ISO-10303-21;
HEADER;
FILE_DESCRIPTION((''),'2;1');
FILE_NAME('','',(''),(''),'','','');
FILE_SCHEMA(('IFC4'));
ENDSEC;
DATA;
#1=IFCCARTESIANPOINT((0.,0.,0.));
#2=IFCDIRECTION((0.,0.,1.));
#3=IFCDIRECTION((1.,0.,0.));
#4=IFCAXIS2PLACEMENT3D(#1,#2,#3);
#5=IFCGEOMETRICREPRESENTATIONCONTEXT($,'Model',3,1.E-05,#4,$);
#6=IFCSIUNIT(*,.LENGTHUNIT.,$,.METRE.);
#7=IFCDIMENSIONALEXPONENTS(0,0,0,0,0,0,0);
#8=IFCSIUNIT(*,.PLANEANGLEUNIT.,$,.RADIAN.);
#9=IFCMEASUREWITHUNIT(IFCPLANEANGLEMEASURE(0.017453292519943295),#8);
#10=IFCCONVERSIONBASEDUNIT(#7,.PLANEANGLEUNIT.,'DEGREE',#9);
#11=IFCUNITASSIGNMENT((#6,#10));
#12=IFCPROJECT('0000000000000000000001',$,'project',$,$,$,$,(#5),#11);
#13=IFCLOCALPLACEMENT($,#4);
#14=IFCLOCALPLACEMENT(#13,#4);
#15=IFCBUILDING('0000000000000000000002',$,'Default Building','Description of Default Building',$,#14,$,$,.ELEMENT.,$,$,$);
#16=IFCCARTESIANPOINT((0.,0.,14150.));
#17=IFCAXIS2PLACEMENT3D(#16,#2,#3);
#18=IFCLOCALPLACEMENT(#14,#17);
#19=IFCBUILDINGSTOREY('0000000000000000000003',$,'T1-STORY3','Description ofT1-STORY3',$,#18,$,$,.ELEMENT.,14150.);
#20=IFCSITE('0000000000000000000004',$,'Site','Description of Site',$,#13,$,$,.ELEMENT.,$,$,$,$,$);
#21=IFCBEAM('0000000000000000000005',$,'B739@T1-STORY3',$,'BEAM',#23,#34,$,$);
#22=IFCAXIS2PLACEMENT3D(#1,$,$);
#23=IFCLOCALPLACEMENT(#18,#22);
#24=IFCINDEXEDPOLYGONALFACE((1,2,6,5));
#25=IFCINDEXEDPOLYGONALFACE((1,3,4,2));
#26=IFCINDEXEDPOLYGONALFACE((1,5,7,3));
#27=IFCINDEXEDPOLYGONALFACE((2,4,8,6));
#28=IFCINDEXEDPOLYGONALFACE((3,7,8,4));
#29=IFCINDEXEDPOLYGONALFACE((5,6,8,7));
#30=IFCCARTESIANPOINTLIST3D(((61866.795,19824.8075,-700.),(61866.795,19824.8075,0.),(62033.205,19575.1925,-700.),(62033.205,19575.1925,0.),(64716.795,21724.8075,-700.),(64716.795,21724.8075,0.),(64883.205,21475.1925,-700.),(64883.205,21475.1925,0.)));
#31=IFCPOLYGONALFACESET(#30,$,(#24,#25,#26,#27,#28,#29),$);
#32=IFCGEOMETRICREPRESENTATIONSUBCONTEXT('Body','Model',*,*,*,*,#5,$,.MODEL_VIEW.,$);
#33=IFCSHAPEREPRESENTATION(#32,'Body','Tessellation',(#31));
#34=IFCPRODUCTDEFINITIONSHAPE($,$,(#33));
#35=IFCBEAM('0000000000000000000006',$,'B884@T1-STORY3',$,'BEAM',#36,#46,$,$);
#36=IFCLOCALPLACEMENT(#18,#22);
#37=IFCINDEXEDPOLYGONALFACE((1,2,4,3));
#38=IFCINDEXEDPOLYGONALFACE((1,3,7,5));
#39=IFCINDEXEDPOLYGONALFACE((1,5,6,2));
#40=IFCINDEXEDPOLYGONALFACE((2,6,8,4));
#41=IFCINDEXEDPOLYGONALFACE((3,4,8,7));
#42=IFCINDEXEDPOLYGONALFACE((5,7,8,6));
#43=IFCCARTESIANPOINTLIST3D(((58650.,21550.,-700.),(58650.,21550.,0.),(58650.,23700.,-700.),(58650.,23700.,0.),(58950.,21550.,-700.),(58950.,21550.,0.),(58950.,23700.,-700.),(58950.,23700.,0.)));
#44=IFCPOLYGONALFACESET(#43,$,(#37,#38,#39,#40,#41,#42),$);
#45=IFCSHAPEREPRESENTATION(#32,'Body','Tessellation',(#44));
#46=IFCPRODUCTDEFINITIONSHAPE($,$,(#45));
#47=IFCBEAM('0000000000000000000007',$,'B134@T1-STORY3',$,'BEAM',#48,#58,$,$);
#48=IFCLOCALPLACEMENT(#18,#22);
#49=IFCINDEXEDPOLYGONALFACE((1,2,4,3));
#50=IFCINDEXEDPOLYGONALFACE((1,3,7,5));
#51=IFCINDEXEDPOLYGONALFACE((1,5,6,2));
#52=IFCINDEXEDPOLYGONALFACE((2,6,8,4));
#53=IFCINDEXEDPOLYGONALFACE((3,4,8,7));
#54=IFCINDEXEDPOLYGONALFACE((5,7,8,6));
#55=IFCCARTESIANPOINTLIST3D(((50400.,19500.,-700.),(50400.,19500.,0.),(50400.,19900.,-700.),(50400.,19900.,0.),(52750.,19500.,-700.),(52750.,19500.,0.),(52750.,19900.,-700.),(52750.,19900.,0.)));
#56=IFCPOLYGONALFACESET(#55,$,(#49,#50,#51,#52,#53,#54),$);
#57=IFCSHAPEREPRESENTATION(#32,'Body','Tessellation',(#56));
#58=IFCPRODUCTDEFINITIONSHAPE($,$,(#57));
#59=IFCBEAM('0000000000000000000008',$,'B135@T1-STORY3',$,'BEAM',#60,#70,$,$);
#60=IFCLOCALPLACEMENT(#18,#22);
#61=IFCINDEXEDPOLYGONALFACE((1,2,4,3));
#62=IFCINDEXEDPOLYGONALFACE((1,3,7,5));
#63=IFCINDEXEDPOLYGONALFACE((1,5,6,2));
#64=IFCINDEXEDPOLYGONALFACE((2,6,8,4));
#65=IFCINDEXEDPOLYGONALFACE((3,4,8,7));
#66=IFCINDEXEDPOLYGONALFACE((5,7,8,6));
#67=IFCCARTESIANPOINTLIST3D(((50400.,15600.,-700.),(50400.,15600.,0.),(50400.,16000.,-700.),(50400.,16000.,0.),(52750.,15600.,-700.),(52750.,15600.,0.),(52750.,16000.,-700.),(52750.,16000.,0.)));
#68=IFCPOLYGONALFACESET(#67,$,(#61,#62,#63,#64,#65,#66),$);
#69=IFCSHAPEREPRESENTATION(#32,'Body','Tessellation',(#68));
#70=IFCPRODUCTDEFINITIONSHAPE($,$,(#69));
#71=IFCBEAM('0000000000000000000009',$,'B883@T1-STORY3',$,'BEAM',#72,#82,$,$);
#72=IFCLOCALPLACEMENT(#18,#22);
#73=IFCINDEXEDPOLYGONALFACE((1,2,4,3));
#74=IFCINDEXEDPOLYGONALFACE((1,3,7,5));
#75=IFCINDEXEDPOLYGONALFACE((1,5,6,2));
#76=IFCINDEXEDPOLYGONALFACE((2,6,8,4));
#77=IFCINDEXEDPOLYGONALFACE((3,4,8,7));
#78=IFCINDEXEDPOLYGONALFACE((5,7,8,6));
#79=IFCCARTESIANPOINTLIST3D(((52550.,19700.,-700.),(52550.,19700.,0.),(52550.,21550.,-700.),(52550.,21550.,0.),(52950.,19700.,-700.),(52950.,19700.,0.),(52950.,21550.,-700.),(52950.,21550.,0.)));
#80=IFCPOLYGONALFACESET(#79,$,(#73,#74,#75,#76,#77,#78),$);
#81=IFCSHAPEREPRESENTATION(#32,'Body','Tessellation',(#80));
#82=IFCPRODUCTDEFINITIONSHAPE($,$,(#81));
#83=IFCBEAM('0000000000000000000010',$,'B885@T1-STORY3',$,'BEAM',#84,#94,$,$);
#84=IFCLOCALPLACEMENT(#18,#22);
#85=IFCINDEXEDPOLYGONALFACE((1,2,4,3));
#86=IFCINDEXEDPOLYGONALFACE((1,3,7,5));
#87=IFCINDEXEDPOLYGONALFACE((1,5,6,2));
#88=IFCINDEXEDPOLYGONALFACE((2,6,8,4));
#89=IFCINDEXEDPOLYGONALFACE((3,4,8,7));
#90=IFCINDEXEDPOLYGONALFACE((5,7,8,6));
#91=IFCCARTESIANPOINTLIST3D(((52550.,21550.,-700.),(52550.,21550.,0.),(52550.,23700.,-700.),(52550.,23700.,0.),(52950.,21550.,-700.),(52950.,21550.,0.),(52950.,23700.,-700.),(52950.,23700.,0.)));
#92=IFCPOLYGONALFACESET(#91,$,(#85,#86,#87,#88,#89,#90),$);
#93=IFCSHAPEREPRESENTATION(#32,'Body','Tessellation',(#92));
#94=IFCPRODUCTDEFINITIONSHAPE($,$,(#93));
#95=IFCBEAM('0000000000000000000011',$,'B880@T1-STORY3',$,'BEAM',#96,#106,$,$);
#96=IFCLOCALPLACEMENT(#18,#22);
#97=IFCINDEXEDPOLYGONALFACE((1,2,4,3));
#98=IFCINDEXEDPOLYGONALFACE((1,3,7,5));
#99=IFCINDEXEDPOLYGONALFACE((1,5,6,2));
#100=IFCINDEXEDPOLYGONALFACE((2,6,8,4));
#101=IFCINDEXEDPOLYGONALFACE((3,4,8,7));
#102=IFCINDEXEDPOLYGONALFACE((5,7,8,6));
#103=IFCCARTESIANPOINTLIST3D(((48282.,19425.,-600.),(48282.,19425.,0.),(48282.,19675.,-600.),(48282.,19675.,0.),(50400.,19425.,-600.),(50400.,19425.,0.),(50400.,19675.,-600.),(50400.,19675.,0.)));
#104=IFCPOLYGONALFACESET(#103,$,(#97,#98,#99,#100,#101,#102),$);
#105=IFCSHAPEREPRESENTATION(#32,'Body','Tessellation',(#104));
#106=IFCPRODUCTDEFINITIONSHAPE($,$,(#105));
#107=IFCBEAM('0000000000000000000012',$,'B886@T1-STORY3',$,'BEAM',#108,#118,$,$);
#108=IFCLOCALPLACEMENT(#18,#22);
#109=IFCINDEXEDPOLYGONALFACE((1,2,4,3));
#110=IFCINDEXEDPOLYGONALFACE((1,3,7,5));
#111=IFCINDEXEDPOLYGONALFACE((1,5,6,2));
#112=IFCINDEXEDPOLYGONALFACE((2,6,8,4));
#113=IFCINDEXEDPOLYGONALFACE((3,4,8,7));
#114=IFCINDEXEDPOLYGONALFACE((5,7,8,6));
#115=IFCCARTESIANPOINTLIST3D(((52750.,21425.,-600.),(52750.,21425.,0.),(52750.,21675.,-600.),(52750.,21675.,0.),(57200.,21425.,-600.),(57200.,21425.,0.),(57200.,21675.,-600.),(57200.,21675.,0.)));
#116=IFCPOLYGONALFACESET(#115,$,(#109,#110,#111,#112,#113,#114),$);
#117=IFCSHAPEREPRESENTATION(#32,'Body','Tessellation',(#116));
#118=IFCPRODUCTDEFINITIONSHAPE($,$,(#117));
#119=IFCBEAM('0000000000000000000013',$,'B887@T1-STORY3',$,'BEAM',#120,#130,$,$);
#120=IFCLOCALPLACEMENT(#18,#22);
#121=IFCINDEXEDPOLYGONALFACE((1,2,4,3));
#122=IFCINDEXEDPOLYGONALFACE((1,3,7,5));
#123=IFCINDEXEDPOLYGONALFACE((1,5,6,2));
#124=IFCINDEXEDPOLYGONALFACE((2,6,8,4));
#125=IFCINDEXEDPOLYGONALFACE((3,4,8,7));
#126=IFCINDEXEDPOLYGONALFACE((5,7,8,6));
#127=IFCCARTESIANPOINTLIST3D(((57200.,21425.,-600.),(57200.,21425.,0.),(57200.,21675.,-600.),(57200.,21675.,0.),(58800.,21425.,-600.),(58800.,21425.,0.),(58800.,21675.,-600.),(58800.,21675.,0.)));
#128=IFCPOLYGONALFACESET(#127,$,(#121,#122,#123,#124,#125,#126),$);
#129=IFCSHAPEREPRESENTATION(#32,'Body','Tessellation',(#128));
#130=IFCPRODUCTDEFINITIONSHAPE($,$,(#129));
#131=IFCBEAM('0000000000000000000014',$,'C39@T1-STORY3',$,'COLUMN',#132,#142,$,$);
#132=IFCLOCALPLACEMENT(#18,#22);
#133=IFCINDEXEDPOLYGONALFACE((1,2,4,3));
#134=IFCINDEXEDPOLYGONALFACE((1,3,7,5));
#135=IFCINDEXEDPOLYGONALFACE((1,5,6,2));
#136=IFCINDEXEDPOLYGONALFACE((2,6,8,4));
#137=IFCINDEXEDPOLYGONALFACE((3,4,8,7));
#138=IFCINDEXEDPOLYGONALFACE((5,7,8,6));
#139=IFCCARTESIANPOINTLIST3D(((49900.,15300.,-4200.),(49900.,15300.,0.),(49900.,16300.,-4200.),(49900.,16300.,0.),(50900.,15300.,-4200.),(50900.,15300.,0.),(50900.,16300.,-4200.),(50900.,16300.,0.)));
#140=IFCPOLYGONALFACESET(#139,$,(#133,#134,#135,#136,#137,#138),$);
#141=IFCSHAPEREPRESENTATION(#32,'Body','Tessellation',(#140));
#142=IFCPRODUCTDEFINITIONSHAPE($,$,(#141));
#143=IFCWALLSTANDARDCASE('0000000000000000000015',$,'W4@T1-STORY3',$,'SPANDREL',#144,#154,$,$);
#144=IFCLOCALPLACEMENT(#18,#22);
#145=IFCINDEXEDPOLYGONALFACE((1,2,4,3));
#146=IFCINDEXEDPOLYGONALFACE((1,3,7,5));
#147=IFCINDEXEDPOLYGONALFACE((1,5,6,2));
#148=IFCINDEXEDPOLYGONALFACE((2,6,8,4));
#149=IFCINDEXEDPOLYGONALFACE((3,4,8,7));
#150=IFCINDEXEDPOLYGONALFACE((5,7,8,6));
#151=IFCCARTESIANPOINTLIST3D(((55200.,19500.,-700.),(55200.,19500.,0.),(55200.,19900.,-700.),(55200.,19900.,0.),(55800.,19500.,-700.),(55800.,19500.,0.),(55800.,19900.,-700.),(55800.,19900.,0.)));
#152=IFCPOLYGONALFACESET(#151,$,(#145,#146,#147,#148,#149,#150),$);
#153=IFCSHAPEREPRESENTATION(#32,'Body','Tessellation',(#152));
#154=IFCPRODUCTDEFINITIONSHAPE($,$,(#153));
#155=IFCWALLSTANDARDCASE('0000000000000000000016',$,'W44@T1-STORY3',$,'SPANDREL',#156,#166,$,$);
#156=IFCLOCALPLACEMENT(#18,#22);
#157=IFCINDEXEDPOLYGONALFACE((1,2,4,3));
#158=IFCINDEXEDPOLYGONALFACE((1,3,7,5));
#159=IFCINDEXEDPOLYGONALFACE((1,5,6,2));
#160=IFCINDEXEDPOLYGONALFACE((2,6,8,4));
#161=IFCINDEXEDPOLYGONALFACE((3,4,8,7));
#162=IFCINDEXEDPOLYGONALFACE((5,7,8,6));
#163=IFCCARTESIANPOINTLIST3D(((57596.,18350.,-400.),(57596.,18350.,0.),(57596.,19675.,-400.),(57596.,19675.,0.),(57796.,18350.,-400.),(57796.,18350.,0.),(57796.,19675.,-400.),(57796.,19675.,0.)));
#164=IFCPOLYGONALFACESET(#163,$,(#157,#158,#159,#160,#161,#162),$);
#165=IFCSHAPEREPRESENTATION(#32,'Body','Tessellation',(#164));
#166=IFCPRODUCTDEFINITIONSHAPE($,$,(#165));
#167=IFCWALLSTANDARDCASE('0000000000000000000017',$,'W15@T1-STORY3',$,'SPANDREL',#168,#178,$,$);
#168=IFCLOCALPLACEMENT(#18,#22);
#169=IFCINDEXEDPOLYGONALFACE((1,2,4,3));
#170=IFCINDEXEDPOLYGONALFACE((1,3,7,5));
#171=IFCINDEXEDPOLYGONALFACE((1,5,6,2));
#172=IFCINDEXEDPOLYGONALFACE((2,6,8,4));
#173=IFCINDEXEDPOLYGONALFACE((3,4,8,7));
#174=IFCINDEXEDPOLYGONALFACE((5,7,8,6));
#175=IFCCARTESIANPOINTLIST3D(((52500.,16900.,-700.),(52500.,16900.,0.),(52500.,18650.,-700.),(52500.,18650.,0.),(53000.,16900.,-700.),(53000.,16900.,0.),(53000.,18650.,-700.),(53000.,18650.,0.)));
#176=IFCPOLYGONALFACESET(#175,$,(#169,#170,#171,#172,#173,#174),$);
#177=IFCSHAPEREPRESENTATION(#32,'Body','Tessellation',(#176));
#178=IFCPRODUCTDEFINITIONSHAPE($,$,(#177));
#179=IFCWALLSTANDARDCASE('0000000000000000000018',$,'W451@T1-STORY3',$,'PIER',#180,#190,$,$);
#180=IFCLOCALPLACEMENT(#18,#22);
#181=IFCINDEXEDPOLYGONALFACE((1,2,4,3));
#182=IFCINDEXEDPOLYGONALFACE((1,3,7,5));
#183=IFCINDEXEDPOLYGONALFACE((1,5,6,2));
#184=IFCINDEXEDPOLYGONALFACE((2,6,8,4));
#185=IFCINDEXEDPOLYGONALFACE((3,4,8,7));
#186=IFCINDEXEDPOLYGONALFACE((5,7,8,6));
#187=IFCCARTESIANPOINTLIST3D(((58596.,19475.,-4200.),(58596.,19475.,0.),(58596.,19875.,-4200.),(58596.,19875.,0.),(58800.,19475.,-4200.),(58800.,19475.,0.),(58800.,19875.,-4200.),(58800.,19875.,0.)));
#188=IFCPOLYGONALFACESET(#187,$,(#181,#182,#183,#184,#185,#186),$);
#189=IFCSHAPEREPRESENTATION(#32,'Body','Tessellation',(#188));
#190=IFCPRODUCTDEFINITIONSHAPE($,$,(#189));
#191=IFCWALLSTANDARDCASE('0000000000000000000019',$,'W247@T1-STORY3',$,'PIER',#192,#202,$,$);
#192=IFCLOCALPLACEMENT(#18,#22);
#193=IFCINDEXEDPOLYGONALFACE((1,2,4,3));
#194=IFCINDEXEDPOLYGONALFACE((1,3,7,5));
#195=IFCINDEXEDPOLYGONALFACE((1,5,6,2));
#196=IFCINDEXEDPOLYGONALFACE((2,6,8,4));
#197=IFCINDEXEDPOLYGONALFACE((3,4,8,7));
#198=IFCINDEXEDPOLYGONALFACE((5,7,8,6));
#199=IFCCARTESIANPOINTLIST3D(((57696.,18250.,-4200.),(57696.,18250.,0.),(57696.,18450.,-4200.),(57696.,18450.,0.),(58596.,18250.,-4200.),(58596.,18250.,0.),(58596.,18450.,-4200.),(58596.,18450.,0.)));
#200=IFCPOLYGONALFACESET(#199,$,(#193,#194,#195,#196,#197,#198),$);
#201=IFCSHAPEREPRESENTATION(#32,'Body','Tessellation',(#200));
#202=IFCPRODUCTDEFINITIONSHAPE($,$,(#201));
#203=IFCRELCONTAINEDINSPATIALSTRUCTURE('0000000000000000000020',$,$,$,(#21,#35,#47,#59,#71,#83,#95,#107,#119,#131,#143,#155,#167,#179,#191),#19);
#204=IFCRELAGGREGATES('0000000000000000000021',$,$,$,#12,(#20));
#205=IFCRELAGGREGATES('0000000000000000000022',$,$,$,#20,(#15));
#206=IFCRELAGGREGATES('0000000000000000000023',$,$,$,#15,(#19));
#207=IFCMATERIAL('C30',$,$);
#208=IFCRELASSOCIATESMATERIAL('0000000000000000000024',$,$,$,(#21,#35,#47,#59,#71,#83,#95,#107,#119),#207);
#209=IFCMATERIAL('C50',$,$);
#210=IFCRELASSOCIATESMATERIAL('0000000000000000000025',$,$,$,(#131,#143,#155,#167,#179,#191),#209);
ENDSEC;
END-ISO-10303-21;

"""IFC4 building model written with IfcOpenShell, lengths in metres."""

from ifc_helpers import new_model, entity, si_unit, converted_unit, frame, origin_with_axes, place, context, subcontext, project, spatial, indexed_curve, rectangle, outline, extrude, material, element, save


model = new_model("IFC4")

# Units and contexts
model_context = context("Model", 3, precision=1e-05, world=origin_with_axes())
body_context = subcontext(model_context, "Body", "Model", "MODEL_VIEW")
ifc_project = project(units=[si_unit("LENGTHUNIT", "METRE"), converted_unit("PLANEANGLEUNIT", "DEGREE", entity("IfcPlaneAngleMeasure", 0.017453292519943295), si_unit("PLANEANGLEUNIT", "RADIAN"), dimensions=[0, 0, 0, 0, 0, 0, 0])], contexts=[model_context])

# Site, building, storey
site_placement = place(None, origin_with_axes())
site = spatial("IfcSite", under=ifc_project, at=site_placement, Name="Site", Description="Description of Site", CompositionType="ELEMENT")
building_placement = place(site_placement, origin_with_axes())
building = spatial("IfcBuilding", under=site, at=building_placement, Name="Default Building", Description="Description of Default Building", CompositionType="ELEMENT")
storey_placement = place(building_placement, frame((0.0, 0.0, 14150.0), z_axis=(0.0, 0.0, 1.0), x_axis=(1.0, 0.0, 0.0)))
storey = spatial("IfcBuildingStorey", under=building, at=storey_placement, Name="T1-STORY3", Description="Description ofT1-STORY3", CompositionType="ELEMENT", Elevation=14150.0)

# Beams
ifc_material_1 = material(Name="C30")
beam_1_placement = place(storey_placement, frame((61950.0, 19700.0, -350.0), z_axis=(0.83205, 0.5547, 0.0), x_axis=(-0.5547, 0.83205, 0.0)))
element("IfcBeam", 1, at=beam_1_placement, inside=storey, material=ifc_material_1, Name="B739@T1-STORY3", ObjectType="BEAM", context=body_context, shape_type="SweptSolid", body=[
    extrude(rectangle(XDim=300.0, YDim=700.0), origin_with_axes(), (0.0, 0.0, 1.0), 3425.2737),
])
beam_2_placement = place(storey_placement, frame((58800.0, 21550.0, -350.0), z_axis=(0.0, 1.0, 0.0), x_axis=(-1.0, 0.0, 0.0)))
element("IfcBeam", 2, at=beam_2_placement, inside=storey, material=ifc_material_1, Name="B884@T1-STORY3", ObjectType="BEAM", context=body_context, shape_type="SweptSolid", body=[
    extrude(rectangle(XDim=300.0, YDim=700.0), origin_with_axes(), (0.0, 0.0, 1.0), 2150.0),
])
for number, where, z_axis, x_axis, name in (
    (3, (50400.0, 19700.0, -350.0), (1.0, 0.0, 0.0), (0.0, 1.0, 0.0), "B134@T1-STORY3"),
    (4, (50400.0, 15800.0, -350.0), (1.0, 0.0, 0.0), (0.0, 1.0, 0.0), "B135@T1-STORY3"),
):
    element("IfcBeam", number, at=place(storey_placement, frame(where, z_axis=z_axis, x_axis=x_axis)), inside=storey, material=ifc_material_1, Name=name, ObjectType="BEAM", context=body_context, shape_type="SweptSolid", body=[
        extrude(rectangle(XDim=400.0, YDim=700.0), origin_with_axes(), (0.0, 0.0, 1.0), 2350.0),
    ])
beam_3_placement = place(storey_placement, frame((52750.0, 19700.0, -350.0), z_axis=(0.0, 1.0, 0.0), x_axis=(-1.0, 0.0, 0.0)))
element("IfcBeam", 5, at=beam_3_placement, inside=storey, material=ifc_material_1, Name="B883@T1-STORY3", ObjectType="BEAM", context=body_context, shape_type="SweptSolid", body=[
    extrude(rectangle(XDim=400.0, YDim=700.0), origin_with_axes(), (0.0, 0.0, 1.0), 1850.0),
])
beam_4_placement = place(storey_placement, frame((52750.0, 21550.0, -350.0), z_axis=(0.0, 1.0, 0.0), x_axis=(-1.0, 0.0, 0.0)))
element("IfcBeam", 6, at=beam_4_placement, inside=storey, material=ifc_material_1, Name="B885@T1-STORY3", ObjectType="BEAM", context=body_context, shape_type="SweptSolid", body=[
    extrude(rectangle(XDim=400.0, YDim=700.0), origin_with_axes(), (0.0, 0.0, 1.0), 2150.0),
])
beam_5_placement = place(storey_placement, frame((48282.0, 19550.0, -300.0), z_axis=(1.0, 0.0, 0.0), x_axis=(0.0, 1.0, 0.0)))
element("IfcBeam", 7, at=beam_5_placement, inside=storey, material=ifc_material_1, Name="B880@T1-STORY3", ObjectType="BEAM", context=body_context, shape_type="SweptSolid", body=[
    extrude(rectangle(XDim=250.0, YDim=600.0), origin_with_axes(), (0.0, 0.0, 1.0), 2118.0),
])
beam_6_placement = place(storey_placement, frame((52750.0, 21550.0, -300.0), z_axis=(1.0, 0.0, 0.0), x_axis=(0.0, 1.0, 0.0)))
element("IfcBeam", 8, at=beam_6_placement, inside=storey, material=ifc_material_1, Name="B886@T1-STORY3", ObjectType="BEAM", context=body_context, shape_type="SweptSolid", body=[
    extrude(rectangle(XDim=250.0, YDim=600.0), origin_with_axes(), (0.0, 0.0, 1.0), 4450.0),
])
beam_7_placement = place(storey_placement, frame((57200.0, 21550.0, -300.0), z_axis=(1.0, 0.0, 0.0), x_axis=(0.0, 1.0, 0.0)))
element("IfcBeam", 9, at=beam_7_placement, inside=storey, material=ifc_material_1, Name="B887@T1-STORY3", ObjectType="BEAM", context=body_context, shape_type="SweptSolid", body=[
    extrude(rectangle(XDim=250.0, YDim=600.0), origin_with_axes(), (0.0, 0.0, 1.0), 1600.0),
])
ifc_material_2 = material(Name="C50")
beam_8_placement = place(storey_placement, frame((50400.0, 15800.0, -4200.0), z_axis=(0.0, 0.0, 1.0), x_axis=(-1.0, 0.0, 0.0)))
element("IfcBeam", 10, at=beam_8_placement, inside=storey, material=ifc_material_2, Name="C39@T1-STORY3", ObjectType="COLUMN", context=body_context, shape_type="SweptSolid", body=[
    extrude(rectangle(XDim=1000.0, YDim=1000.0), origin_with_axes(), (0.0, 0.0, 1.0), 4200.0),
])

# Walls
wall_1_placement = place(storey_placement, frame((55200.0, 19700.0, -700.0), z_axis=(0.0, 0.0, 1.0), x_axis=(1.0, 0.0, 0.0)))
element("IfcWallStandardCase", 11, at=wall_1_placement, inside=storey, material=ifc_material_2, Name="W4@T1-STORY3", ObjectType="SPANDREL", context=body_context, shape_type="SweptSolid", body=[
    extrude(outline(indexed_curve([(0.0, -200.0), (0.0, 200.0), (600.0, 200.0), (600.0, -200.0), (0.0, -200.0)], self_intersect=False)), origin_with_axes(), (0.0, 0.0, 1.0), 700.0),
])
wall_2_placement = place(storey_placement, frame((57696.0, 18350.0, -400.0), z_axis=(0.0, 0.0, 1.0), x_axis=(0.0, 1.0, 0.0)))
element("IfcWallStandardCase", 12, at=wall_2_placement, inside=storey, material=ifc_material_2, Name="W44@T1-STORY3", ObjectType="SPANDREL", context=body_context, shape_type="SweptSolid", body=[
    extrude(outline(indexed_curve([(0.0, -100.0), (0.0, 100.0), (1325.0, 100.0), (1325.0, -100.0), (0.0, -100.0)], self_intersect=False)), origin_with_axes(), (0.0, 0.0, 1.0), 400.0),
])
wall_3_placement = place(storey_placement, frame((52750.0, 16900.0, -700.0), z_axis=(0.0, 0.0, 1.0), x_axis=(0.0, 1.0, 0.0)))
element("IfcWallStandardCase", 13, at=wall_3_placement, inside=storey, material=ifc_material_2, Name="W15@T1-STORY3", ObjectType="SPANDREL", context=body_context, shape_type="SweptSolid", body=[
    extrude(outline(indexed_curve([(0.0, -250.0), (0.0, 250.0), (1750.0, 250.0), (1750.0, -250.0), (0.0, -250.0)], self_intersect=False)), origin_with_axes(), (0.0, 0.0, 1.0), 700.0),
])
wall_4_placement = place(storey_placement, frame((58596.0, 19675.0, -4200.0), z_axis=(0.0, 0.0, 1.0), x_axis=(1.0, 0.0, 0.0)))
element("IfcWallStandardCase", 14, at=wall_4_placement, inside=storey, material=ifc_material_2, Name="W451@T1-STORY3", ObjectType="PIER", context=body_context, shape_type="SweptSolid", body=[
    extrude(outline(indexed_curve([(0.0, -200.0), (0.0, 200.0), (204.0, 200.0), (204.0, -200.0), (0.0, -200.0)], self_intersect=False)), origin_with_axes(), (0.0, 0.0, 1.0), 4200.0),
])
wall_5_placement = place(storey_placement, frame((57696.0, 18350.0, -4200.0), z_axis=(0.0, 0.0, 1.0), x_axis=(1.0, 0.0, 0.0)))
element("IfcWallStandardCase", 15, at=wall_5_placement, inside=storey, material=ifc_material_2, Name="W247@T1-STORY3", ObjectType="PIER", context=body_context, shape_type="SweptSolid", body=[
    extrude(outline(indexed_curve([(0.0, -100.0), (0.0, 100.0), (900.0, 100.0), (900.0, -100.0), (0.0, -100.0)], self_intersect=False)), origin_with_axes(), (0.0, 0.0, 1.0), 4200.0),
])

save(model, "model.ifc")
